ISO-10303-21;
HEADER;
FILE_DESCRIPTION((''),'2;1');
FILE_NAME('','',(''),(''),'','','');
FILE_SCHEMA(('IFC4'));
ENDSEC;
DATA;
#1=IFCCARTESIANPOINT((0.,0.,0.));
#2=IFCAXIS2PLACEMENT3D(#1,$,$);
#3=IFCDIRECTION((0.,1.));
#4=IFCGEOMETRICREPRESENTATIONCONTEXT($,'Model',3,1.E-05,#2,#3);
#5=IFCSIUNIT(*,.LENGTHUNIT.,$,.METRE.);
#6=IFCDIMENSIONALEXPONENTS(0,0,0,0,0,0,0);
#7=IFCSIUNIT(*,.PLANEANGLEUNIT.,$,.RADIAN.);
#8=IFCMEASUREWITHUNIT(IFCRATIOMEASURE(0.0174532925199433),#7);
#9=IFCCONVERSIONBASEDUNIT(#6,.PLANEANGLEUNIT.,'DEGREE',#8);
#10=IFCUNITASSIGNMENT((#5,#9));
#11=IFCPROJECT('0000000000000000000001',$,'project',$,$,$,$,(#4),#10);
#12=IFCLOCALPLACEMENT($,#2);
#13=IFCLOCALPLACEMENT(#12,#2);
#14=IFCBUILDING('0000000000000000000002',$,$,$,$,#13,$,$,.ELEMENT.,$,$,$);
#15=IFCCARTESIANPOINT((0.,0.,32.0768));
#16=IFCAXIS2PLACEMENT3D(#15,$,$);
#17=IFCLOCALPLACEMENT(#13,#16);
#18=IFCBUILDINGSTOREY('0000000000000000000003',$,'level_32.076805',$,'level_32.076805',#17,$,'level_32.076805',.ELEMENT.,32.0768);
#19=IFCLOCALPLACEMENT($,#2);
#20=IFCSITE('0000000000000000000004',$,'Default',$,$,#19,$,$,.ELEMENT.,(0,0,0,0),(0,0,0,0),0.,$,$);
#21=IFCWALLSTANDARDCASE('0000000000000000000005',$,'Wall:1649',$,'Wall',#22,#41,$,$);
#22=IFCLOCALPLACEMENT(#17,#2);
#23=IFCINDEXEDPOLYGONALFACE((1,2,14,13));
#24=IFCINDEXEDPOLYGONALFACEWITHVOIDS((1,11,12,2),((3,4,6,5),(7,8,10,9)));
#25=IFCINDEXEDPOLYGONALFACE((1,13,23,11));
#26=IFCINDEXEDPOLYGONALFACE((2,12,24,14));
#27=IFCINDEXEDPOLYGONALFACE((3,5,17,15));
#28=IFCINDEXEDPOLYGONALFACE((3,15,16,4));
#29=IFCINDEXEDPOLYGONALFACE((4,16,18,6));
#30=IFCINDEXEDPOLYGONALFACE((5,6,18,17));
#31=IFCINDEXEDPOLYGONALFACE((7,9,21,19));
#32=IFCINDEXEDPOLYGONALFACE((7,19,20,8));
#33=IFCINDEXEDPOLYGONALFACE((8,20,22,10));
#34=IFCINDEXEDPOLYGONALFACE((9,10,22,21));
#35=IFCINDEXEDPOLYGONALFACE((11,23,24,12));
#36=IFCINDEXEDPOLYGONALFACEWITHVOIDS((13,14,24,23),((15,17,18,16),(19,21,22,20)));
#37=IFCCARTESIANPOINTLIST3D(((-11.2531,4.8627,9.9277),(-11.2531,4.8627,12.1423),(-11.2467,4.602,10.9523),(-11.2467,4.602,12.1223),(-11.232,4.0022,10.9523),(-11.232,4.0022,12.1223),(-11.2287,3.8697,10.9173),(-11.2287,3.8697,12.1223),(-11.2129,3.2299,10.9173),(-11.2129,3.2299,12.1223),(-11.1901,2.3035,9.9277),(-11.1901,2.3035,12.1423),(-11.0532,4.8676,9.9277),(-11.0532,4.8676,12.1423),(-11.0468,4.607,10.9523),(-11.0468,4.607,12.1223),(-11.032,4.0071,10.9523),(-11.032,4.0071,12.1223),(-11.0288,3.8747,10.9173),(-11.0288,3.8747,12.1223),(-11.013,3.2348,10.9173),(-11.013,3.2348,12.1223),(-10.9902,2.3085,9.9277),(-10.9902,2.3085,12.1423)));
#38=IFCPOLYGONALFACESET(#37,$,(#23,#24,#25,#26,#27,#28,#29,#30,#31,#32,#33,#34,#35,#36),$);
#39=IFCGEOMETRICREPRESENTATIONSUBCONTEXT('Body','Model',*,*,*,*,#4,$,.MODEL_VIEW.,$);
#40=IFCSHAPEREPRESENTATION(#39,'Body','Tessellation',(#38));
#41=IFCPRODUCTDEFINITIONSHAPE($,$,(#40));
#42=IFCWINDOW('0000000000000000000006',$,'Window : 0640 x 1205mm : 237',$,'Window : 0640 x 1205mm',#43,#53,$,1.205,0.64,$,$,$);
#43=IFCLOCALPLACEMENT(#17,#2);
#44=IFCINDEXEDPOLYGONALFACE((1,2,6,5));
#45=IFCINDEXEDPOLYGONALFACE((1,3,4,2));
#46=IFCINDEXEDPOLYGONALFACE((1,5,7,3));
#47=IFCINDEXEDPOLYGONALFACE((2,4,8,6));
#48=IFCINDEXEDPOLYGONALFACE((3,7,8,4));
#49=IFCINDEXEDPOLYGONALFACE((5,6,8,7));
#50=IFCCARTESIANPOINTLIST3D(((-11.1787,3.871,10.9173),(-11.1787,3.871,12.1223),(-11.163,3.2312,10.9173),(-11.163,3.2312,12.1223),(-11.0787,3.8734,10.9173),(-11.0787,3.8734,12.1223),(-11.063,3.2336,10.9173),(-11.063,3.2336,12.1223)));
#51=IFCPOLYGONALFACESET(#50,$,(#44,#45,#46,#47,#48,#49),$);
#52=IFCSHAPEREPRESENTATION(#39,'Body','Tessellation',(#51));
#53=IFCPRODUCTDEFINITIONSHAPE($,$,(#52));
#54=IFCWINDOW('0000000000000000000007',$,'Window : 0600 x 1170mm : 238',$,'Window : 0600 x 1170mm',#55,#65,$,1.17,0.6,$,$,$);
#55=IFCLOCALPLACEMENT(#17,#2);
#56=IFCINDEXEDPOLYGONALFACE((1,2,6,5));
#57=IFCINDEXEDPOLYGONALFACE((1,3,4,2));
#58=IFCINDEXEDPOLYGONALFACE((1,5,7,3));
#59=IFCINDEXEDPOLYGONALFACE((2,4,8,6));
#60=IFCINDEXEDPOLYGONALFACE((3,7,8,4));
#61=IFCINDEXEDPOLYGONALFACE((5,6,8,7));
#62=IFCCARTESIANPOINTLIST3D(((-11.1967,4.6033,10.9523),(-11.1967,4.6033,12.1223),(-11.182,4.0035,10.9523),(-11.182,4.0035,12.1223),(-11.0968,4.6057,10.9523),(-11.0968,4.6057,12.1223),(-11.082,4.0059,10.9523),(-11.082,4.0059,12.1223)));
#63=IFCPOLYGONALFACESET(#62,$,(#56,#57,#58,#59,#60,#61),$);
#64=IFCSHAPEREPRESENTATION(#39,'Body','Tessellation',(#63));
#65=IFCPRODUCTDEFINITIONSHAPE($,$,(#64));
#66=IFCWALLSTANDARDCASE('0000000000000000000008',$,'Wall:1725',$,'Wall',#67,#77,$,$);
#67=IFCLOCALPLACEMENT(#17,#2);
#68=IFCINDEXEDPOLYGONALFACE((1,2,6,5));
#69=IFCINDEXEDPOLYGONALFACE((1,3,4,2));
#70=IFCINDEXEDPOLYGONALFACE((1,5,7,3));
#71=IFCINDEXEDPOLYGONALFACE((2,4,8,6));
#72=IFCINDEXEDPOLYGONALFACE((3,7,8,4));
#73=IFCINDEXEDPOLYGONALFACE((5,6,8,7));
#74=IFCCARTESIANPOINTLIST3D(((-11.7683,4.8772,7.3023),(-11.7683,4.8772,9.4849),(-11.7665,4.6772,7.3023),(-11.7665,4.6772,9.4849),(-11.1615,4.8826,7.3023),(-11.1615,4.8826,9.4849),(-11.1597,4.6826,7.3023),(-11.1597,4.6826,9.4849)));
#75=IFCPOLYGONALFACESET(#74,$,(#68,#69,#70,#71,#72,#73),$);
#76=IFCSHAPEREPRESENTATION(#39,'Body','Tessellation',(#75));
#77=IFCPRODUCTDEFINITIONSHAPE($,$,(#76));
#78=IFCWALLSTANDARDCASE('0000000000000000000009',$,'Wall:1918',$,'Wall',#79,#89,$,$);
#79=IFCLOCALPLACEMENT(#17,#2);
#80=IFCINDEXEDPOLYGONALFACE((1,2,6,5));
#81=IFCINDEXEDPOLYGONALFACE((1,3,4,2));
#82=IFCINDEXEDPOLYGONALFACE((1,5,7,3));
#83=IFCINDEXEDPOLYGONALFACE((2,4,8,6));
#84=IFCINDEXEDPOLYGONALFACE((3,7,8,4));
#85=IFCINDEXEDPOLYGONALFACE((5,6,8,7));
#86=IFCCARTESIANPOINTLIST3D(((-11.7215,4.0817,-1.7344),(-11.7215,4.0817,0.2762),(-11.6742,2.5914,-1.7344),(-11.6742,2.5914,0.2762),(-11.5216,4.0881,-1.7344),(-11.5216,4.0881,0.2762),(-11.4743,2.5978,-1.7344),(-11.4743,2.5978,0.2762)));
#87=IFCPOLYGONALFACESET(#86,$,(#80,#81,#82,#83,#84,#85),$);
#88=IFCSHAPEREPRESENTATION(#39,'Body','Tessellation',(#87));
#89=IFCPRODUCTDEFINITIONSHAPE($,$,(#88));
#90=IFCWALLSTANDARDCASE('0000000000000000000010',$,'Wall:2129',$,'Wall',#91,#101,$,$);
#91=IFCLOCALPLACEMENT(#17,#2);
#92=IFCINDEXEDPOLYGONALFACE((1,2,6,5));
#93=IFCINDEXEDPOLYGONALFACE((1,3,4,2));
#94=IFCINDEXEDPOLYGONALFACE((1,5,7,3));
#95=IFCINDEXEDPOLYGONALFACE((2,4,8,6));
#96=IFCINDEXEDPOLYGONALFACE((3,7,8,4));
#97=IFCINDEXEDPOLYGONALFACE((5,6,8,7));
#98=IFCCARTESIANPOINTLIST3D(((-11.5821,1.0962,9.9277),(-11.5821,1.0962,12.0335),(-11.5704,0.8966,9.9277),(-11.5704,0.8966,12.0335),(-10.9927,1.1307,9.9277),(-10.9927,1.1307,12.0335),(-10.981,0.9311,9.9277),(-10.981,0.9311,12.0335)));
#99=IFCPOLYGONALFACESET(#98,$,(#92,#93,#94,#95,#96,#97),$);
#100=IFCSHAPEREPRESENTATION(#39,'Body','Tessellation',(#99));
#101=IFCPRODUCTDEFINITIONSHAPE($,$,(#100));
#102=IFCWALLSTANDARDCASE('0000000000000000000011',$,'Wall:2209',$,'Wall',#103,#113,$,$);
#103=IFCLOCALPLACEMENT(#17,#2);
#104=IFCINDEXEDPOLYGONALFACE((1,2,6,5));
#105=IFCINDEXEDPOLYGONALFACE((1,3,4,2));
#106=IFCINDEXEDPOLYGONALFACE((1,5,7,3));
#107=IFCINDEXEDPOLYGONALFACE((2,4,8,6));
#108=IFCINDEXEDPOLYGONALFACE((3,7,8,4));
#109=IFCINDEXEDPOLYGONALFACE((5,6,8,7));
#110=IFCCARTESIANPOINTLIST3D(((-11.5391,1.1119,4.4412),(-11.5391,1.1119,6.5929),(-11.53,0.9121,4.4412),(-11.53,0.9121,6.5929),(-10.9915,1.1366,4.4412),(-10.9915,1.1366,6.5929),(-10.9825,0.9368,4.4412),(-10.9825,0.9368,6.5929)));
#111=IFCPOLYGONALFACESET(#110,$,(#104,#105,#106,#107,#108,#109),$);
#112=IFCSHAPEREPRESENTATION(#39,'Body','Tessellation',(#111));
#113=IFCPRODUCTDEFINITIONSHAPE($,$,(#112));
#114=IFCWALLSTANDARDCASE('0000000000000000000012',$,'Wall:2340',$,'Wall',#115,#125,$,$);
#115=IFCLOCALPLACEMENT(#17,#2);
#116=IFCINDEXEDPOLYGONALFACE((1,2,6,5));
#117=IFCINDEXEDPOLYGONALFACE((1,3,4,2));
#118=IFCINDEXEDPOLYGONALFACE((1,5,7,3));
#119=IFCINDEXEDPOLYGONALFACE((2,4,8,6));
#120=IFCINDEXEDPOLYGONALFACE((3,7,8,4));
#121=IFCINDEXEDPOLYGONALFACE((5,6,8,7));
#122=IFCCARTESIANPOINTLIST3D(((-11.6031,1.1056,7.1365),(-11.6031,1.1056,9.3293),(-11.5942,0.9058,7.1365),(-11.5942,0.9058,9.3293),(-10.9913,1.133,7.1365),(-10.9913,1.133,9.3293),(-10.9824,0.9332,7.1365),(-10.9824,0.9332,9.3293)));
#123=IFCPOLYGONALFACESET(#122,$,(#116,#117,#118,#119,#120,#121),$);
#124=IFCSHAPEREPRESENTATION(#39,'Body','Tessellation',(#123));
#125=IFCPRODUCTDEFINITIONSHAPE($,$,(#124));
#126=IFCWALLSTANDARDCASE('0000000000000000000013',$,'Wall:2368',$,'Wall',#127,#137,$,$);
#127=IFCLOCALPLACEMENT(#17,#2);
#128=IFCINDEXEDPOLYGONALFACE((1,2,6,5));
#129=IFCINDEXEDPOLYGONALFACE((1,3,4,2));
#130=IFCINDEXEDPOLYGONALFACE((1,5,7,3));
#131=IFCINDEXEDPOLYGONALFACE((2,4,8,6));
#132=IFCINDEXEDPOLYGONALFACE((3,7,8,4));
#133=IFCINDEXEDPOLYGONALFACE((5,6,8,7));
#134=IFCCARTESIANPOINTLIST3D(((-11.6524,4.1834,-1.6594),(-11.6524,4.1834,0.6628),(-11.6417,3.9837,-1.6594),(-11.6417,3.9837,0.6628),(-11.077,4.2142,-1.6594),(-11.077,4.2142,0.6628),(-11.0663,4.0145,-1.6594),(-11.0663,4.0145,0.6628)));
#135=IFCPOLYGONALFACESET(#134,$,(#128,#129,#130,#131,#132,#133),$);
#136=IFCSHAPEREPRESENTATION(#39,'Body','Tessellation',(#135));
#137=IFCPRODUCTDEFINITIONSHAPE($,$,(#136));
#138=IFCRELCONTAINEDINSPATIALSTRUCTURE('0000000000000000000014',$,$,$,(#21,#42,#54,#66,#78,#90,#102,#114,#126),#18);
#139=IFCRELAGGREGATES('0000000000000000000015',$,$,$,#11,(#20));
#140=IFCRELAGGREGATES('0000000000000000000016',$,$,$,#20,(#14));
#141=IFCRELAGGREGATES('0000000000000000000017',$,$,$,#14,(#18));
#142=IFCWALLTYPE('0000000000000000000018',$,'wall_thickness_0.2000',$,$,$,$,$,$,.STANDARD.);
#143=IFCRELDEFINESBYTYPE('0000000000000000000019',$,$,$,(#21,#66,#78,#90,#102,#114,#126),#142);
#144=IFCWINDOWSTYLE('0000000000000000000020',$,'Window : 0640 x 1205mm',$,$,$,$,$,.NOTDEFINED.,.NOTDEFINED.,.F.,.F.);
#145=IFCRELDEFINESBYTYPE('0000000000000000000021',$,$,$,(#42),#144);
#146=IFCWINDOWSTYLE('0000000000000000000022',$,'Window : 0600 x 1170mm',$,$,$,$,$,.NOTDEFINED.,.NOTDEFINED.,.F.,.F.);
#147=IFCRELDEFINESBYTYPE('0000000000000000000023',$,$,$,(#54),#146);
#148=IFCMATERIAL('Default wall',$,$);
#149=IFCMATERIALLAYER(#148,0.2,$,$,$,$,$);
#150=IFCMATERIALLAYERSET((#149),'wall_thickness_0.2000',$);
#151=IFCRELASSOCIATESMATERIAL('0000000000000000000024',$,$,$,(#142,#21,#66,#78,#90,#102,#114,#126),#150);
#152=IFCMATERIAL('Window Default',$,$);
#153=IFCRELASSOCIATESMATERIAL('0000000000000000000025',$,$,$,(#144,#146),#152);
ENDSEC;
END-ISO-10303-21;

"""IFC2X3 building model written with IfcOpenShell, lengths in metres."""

from ifc_helpers import new_model, entity, si_unit, converted_unit, direction, frame, frame_2d, origin, origin_2d_with_axis, place, context, subcontext, project, spatial, polyline, rectangle, outline, extrude, source, transform, mapped, material, layer, layer_set, layer_usage, type_object, type_shapes, element, fill, save


model = new_model("IFC2X3")

# Units and contexts
model_context = context("Model", 3, precision=1e-05, world=origin(), true_north=direction((0.0, 1.0)))
body_context = subcontext(model_context, "Body", "Model", "MODEL_VIEW")
ifc_project = project(units=[si_unit("LENGTHUNIT", "METRE"), converted_unit("PLANEANGLEUNIT", "DEGREE", entity("IfcRatioMeasure", 0.0174532925199433), si_unit("PLANEANGLEUNIT", "RADIAN"), dimensions=[0, 0, 0, 0, 0, 0, 0])], contexts=[model_context])

# Site, building, storey
site_placement = place(None, origin())
site = spatial("IfcSite", under=ifc_project, at=site_placement, Name="Default", CompositionType="ELEMENT", RefLatitude=(0, 0, 0, 0), RefLongitude=(0, 0, 0, 0), RefElevation=0.0)
placement_1 = place(None, origin())
building_placement = place(placement_1, origin())
building = spatial("IfcBuilding", under=site, at=building_placement, CompositionType="ELEMENT")
storey_placement = place(building_placement, frame((0.0, 0.0, 32.0768)))
storey = spatial("IfcBuildingStorey", under=building, at=storey_placement, Name="level_32.076805", ObjectType="level_32.076805", LongName="level_32.076805", CompositionType="ELEMENT", Elevation=32.0768)

# Shared definitions
ifc_material_1 = material(Name="Default wall")
ifc_layer = layer(ifc_material_1, 0.2)
ifc_layer_set = layer_set([ifc_layer], Name="wall_thickness_0.2000")
ifc_layer_usage = layer_usage(ifc_layer_set, "AXIS2", "POSITIVE", -0.1)
wall_type = type_object("IfcWallType", Name="wall_thickness_0.2000", PredefinedType="STANDARD", material=ifc_layer_set)
ifc_material_2 = material(Name="Window Default")

# Wall, openings, windows
placement_2 = place(building_placement, frame((0.0, 0.0, 42.0045)))
wall_1_placement = place(placement_2, frame((-11.0902, 2.306, 0.0), z_axis=(0.0, 0.0, 1.0), x_axis=(-0.02461, 0.999697, 0.0)))
wall_1 = element("IfcWallStandardCase", 1, at=wall_1_placement, inside=storey, type_object=wall_type, material=ifc_layer_usage, Name="Wall:1649", ObjectType="Wall", context=body_context, shape_type="SweptSolid", body=[
    extrude(outline(polyline([(2.5599, -0.1), (2.5599, 0.1), (0.0, 0.1), (0.0, -0.1), (2.5599, -0.1)])), origin(), (0.0, 0.0, 1.0), 2.2146),
])
opening_1_placement = place(wall_1_placement, frame((0.9267, -0.1, 0.9896)))
opening_1 = element("IfcOpeningElement", 2, at=opening_1_placement, cuts=wall_1, ObjectType="Opening", context=body_context, shape_type="SweptSolid", body=[
    extrude(rectangle(XDim=0.64, YDim=1.205, at=frame_2d((0.6025, 0.32), x_axis=(0.0, 1.0))), frame((0.0, 0.0, 0.0), z_axis=(0.0, 1.0, 0.0), x_axis=(0.0, 0.0, 1.0)), (0.0, 0.0, 1.0), 0.2),
])
opening_2_placement = place(wall_1_placement, frame((1.6992, -0.1, 1.0246)))
opening_2 = element("IfcOpeningElement", 3, at=opening_2_placement, cuts=wall_1, ObjectType="Opening", context=body_context, shape_type="SweptSolid", body=[
    extrude(rectangle(XDim=0.6, YDim=1.17, at=frame_2d((0.585, 0.3), x_axis=(0.0, 1.0))), frame((0.0, 0.0, 0.0), z_axis=(0.0, 1.0, 0.0), x_axis=(0.0, 0.0, 1.0)), (0.0, 0.0, 1.0), 0.2),
])
window_style_1 = type_object("IfcWindowStyle", Name="Window : 0640 x 1205mm", ConstructionType="NOTDEFINED", OperationType="NOTDEFINED", ParameterTakesPrecedence=False, Sizeable=False, material=ifc_material_2)
shared_shape_1 = source(origin(), body_context, "Body", "SweptSolid", [
    extrude(rectangle(XDim=0.1, YDim=0.64, at=origin_2d_with_axis()), frame((0.32, 0.1, 0.0), z_axis=(0.0, 0.0, 1.0), x_axis=(0.0, 1.0, 0.0)), (0.0, 0.0, 1.0), 1.205),
])
type_shapes(window_style_1, [shared_shape_1])
window_1_placement = place(opening_1_placement, origin())
window_1 = element("IfcWindow", 4, at=window_1_placement, inside=storey, type_object=window_style_1, Name="Window : 0640 x 1205mm : 237", ObjectType="Window : 0640 x 1205mm", OverallHeight=1.205, OverallWidth=0.64, context=body_context, shape_type="MappedRepresentation", body=[
    mapped(shared_shape_1, transform((0.0, 0.0, 0.0), scale=1.0)),
])
fill(opening_1, window_1)
window_style_2 = type_object("IfcWindowStyle", Name="Window : 0600 x 1170mm", ConstructionType="NOTDEFINED", OperationType="NOTDEFINED", ParameterTakesPrecedence=False, Sizeable=False, material=ifc_material_2)
shared_shape_2 = source(origin(), body_context, "Body", "SweptSolid", [
    extrude(rectangle(XDim=0.1, YDim=0.6, at=origin_2d_with_axis()), frame((0.3, 0.1, 0.0), z_axis=(0.0, 0.0, 1.0), x_axis=(0.0, 1.0, 0.0)), (0.0, 0.0, 1.0), 1.17),
])
type_shapes(window_style_2, [shared_shape_2])
window_2_placement = place(opening_2_placement, origin())
window_2 = element("IfcWindow", 5, at=window_2_placement, inside=storey, type_object=window_style_2, Name="Window : 0600 x 1170mm : 238", ObjectType="Window : 0600 x 1170mm", OverallHeight=1.17, OverallWidth=0.6, context=body_context, shape_type="MappedRepresentation", body=[
    mapped(shared_shape_2, transform((0.0, 0.0, 0.0), scale=1.0)),
])
fill(opening_2, window_2)

# Walls
placement_3 = place(building_placement, frame((0.0, 0.0, 39.3791)))
wall_2_placement = place(placement_3, frame((-11.1606, 4.7826, 0.0), z_axis=(0.0, 0.0, 1.0), x_axis=(-0.999959, -0.009019, 0.0)))
element("IfcWallStandardCase", 6, at=wall_2_placement, inside=storey, type_object=wall_type, material=ifc_layer_usage, Name="Wall:1725", ObjectType="Wall", context=body_context, shape_type="SweptSolid", body=[
    extrude(outline(polyline([(0.6068, -0.1), (0.6068, 0.1), (0.0, 0.1), (0.0, -0.1), (0.6068, -0.1)])), origin(), (0.0, 0.0, 1.0), 2.1825),
])
placement_4 = place(building_placement, frame((0.0, 0.0, 30.3424)))
wall_3_placement = place(placement_4, frame((-11.5743, 2.5946, 0.0), z_axis=(0.0, 0.0, 1.0), x_axis=(-0.031723, 0.999497, 0.0)))
element("IfcWallStandardCase", 7, at=wall_3_placement, inside=storey, type_object=wall_type, material=ifc_layer_usage, Name="Wall:1918", ObjectType="Wall", context=body_context, shape_type="SweptSolid", body=[
    extrude(outline(polyline([(1.4911, -0.1), (1.4911, 0.1), (0.0, 0.1), (0.0, -0.1), (1.4911, -0.1)])), origin(), (0.0, 0.0, 1.0), 2.0106),
])
placement_5 = place(building_placement, frame((0.0, 0.0, 42.0045)))
wall_4_placement = place(placement_5, frame((-10.9868, 1.0309, 0.0), z_axis=(0.0, 0.0, 1.0), x_axis=(-0.998292, -0.058425, 0.0)))
element("IfcWallStandardCase", 8, at=wall_4_placement, inside=storey, type_object=wall_type, material=ifc_layer_usage, Name="Wall:2129", ObjectType="Wall", context=body_context, shape_type="SweptSolid", body=[
    extrude(outline(polyline([(0.5904, -0.1), (0.5904, 0.1), (0.0, 0.1), (0.0, -0.1), (0.5904, -0.1)])), origin(), (0.0, 0.0, 1.0), 2.1058),
])
placement_6 = place(building_placement, frame((0.0, 0.0, 36.518)))
wall_5_placement = place(placement_6, frame((-10.987, 1.0367, 0.0), z_axis=(0.0, 0.0, 1.0), x_axis=(-0.998984, -0.045061, 0.0)))
element("IfcWallStandardCase", 9, at=wall_5_placement, inside=storey, type_object=wall_type, material=ifc_layer_usage, Name="Wall:2209", ObjectType="Wall", context=body_context, shape_type="SweptSolid", body=[
    extrude(outline(polyline([(0.5481, -0.1), (0.5481, 0.1), (0.0, 0.1), (0.0, -0.1), (0.5481, -0.1)])), origin(), (0.0, 0.0, 1.0), 2.1518),
])
placement_7 = place(building_placement, frame((0.0, 0.0, 39.2133)))
wall_6_placement = place(placement_7, frame((-10.9869, 1.0331, 0.0), z_axis=(0.0, 0.0, 1.0), x_axis=(-0.999005, -0.044605, 0.0)))
element("IfcWallStandardCase", 10, at=wall_6_placement, inside=storey, type_object=wall_type, material=ifc_layer_usage, Name="Wall:2340", ObjectType="Wall", context=body_context, shape_type="SweptSolid", body=[
    extrude(outline(polyline([(0.6123, -0.1), (0.6123, 0.1), (0.0, 0.1), (0.0, -0.1), (0.6123, -0.1)])), origin(), (0.0, 0.0, 1.0), 2.1928),
])
placement_8 = place(building_placement, frame((0.0, 0.0, 30.4174)))
wall_7_placement = place(placement_8, frame((-11.0717, 4.1143, 0.0), z_axis=(0.0, 0.0, 1.0), x_axis=(-0.998573, -0.053398, 0.0)))
element("IfcWallStandardCase", 11, at=wall_7_placement, inside=storey, type_object=wall_type, material=ifc_layer_usage, Name="Wall:2368", ObjectType="Wall", context=body_context, shape_type="SweptSolid", body=[
    extrude(outline(polyline([(0.5762, -0.1), (0.5762, 0.1), (0.0, 0.1), (0.0, -0.1), (0.5762, -0.1)])), origin(), (0.0, 0.0, 1.0), 2.3222),
])

save(model, "model.ifc")
